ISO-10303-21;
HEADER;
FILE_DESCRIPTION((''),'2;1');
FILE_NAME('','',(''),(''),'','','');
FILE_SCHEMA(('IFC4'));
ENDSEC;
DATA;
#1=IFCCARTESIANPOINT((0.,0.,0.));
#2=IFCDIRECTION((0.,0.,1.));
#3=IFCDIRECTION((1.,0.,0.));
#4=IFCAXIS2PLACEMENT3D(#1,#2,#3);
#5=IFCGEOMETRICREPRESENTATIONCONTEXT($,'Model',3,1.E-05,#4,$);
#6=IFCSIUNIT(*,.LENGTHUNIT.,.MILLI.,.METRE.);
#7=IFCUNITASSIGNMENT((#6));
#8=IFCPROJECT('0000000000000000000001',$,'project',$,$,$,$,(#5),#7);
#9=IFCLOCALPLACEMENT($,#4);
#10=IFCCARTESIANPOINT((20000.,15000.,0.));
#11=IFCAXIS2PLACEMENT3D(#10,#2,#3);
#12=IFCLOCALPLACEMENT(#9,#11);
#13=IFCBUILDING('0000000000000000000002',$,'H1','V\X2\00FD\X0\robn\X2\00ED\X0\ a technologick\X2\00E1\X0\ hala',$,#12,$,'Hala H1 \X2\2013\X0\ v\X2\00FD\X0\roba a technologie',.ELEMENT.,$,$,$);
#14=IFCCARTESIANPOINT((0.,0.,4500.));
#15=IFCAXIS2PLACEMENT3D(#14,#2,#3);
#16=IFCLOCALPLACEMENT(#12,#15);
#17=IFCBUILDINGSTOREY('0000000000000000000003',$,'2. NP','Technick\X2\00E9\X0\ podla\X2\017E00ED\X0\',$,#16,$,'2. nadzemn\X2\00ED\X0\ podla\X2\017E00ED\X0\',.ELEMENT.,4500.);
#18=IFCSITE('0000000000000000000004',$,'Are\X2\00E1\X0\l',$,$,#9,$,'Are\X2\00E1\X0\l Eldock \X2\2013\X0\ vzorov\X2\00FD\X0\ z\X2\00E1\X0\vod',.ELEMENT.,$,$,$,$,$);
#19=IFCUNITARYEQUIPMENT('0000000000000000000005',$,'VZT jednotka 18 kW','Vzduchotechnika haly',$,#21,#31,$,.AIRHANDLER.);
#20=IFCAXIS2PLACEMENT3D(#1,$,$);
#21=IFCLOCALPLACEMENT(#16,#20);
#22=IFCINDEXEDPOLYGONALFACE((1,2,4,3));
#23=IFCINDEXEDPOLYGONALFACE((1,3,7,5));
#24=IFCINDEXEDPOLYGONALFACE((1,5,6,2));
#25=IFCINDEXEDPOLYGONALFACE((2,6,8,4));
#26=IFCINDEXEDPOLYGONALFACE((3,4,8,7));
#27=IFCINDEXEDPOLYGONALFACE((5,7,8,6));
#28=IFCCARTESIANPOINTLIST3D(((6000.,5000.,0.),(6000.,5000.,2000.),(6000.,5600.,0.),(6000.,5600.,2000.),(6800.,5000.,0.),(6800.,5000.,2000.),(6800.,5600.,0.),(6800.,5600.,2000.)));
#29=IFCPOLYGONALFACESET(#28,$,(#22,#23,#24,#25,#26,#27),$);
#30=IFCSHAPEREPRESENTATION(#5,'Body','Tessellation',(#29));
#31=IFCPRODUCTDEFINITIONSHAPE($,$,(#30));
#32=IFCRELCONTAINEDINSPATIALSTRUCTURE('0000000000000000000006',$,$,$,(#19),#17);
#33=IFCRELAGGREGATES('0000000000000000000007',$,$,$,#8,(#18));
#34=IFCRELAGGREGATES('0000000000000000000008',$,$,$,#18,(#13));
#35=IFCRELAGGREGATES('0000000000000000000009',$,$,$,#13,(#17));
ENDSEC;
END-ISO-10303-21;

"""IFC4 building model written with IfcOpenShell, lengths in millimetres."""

from ifc_helpers import new_model, si_unit, frame, frame_2d, origin_with_axes, place, context, project, spatial, rectangle, extrude, element, save


model = new_model("IFC4")

# Units and contexts
model_context = context("Model", 3, precision=1e-05, world=origin_with_axes())
ifc_project = project(units=[si_unit("LENGTHUNIT", "METRE", prefix="MILLI")], contexts=[model_context])

# Site, building, storey
site_placement = place(None, origin_with_axes())
site = spatial("IfcSite", under=ifc_project, at=site_placement, Name="Areál", LongName="Areál Eldock – vzorový závod", CompositionType="ELEMENT")
building_placement = place(site_placement, frame((20000.0, 15000.0, 0.0), z_axis=(0.0, 0.0, 1.0), x_axis=(1.0, 0.0, 0.0)))
building = spatial("IfcBuilding", under=site, at=building_placement, Name="H1", Description="Výrobní a technologická hala", LongName="Hala H1 – výroba a technologie", CompositionType="ELEMENT")
storey_placement = place(building_placement, frame((0.0, 0.0, 4500.0), z_axis=(0.0, 0.0, 1.0), x_axis=(1.0, 0.0, 0.0)))
storey = spatial("IfcBuildingStorey", under=building, at=storey_placement, Name="2. NP", Description="Technické podlaží", LongName="2. nadzemní podlaží", CompositionType="ELEMENT", Elevation=4500.0)

# Unitary equipment
unitary_equipment_placement = place(storey_placement, frame((6000.0, 5000.0, 0.0), z_axis=(0.0, 0.0, 1.0), x_axis=(1.0, 0.0, 0.0)))
element("IfcUnitaryEquipment", 1, at=unitary_equipment_placement, inside=storey, Name="VZT jednotka 18 kW", Description="Vzduchotechnika haly", PredefinedType="AIRHANDLER", context=model_context, shape_type="SweptSolid", body=[
    extrude(rectangle(XDim=800.0, YDim=600.0, at=frame_2d((400.0, 300.0))), origin_with_axes(), (0.0, 0.0, 1.0), 2000.0),
])

save(model, "model.ifc")
